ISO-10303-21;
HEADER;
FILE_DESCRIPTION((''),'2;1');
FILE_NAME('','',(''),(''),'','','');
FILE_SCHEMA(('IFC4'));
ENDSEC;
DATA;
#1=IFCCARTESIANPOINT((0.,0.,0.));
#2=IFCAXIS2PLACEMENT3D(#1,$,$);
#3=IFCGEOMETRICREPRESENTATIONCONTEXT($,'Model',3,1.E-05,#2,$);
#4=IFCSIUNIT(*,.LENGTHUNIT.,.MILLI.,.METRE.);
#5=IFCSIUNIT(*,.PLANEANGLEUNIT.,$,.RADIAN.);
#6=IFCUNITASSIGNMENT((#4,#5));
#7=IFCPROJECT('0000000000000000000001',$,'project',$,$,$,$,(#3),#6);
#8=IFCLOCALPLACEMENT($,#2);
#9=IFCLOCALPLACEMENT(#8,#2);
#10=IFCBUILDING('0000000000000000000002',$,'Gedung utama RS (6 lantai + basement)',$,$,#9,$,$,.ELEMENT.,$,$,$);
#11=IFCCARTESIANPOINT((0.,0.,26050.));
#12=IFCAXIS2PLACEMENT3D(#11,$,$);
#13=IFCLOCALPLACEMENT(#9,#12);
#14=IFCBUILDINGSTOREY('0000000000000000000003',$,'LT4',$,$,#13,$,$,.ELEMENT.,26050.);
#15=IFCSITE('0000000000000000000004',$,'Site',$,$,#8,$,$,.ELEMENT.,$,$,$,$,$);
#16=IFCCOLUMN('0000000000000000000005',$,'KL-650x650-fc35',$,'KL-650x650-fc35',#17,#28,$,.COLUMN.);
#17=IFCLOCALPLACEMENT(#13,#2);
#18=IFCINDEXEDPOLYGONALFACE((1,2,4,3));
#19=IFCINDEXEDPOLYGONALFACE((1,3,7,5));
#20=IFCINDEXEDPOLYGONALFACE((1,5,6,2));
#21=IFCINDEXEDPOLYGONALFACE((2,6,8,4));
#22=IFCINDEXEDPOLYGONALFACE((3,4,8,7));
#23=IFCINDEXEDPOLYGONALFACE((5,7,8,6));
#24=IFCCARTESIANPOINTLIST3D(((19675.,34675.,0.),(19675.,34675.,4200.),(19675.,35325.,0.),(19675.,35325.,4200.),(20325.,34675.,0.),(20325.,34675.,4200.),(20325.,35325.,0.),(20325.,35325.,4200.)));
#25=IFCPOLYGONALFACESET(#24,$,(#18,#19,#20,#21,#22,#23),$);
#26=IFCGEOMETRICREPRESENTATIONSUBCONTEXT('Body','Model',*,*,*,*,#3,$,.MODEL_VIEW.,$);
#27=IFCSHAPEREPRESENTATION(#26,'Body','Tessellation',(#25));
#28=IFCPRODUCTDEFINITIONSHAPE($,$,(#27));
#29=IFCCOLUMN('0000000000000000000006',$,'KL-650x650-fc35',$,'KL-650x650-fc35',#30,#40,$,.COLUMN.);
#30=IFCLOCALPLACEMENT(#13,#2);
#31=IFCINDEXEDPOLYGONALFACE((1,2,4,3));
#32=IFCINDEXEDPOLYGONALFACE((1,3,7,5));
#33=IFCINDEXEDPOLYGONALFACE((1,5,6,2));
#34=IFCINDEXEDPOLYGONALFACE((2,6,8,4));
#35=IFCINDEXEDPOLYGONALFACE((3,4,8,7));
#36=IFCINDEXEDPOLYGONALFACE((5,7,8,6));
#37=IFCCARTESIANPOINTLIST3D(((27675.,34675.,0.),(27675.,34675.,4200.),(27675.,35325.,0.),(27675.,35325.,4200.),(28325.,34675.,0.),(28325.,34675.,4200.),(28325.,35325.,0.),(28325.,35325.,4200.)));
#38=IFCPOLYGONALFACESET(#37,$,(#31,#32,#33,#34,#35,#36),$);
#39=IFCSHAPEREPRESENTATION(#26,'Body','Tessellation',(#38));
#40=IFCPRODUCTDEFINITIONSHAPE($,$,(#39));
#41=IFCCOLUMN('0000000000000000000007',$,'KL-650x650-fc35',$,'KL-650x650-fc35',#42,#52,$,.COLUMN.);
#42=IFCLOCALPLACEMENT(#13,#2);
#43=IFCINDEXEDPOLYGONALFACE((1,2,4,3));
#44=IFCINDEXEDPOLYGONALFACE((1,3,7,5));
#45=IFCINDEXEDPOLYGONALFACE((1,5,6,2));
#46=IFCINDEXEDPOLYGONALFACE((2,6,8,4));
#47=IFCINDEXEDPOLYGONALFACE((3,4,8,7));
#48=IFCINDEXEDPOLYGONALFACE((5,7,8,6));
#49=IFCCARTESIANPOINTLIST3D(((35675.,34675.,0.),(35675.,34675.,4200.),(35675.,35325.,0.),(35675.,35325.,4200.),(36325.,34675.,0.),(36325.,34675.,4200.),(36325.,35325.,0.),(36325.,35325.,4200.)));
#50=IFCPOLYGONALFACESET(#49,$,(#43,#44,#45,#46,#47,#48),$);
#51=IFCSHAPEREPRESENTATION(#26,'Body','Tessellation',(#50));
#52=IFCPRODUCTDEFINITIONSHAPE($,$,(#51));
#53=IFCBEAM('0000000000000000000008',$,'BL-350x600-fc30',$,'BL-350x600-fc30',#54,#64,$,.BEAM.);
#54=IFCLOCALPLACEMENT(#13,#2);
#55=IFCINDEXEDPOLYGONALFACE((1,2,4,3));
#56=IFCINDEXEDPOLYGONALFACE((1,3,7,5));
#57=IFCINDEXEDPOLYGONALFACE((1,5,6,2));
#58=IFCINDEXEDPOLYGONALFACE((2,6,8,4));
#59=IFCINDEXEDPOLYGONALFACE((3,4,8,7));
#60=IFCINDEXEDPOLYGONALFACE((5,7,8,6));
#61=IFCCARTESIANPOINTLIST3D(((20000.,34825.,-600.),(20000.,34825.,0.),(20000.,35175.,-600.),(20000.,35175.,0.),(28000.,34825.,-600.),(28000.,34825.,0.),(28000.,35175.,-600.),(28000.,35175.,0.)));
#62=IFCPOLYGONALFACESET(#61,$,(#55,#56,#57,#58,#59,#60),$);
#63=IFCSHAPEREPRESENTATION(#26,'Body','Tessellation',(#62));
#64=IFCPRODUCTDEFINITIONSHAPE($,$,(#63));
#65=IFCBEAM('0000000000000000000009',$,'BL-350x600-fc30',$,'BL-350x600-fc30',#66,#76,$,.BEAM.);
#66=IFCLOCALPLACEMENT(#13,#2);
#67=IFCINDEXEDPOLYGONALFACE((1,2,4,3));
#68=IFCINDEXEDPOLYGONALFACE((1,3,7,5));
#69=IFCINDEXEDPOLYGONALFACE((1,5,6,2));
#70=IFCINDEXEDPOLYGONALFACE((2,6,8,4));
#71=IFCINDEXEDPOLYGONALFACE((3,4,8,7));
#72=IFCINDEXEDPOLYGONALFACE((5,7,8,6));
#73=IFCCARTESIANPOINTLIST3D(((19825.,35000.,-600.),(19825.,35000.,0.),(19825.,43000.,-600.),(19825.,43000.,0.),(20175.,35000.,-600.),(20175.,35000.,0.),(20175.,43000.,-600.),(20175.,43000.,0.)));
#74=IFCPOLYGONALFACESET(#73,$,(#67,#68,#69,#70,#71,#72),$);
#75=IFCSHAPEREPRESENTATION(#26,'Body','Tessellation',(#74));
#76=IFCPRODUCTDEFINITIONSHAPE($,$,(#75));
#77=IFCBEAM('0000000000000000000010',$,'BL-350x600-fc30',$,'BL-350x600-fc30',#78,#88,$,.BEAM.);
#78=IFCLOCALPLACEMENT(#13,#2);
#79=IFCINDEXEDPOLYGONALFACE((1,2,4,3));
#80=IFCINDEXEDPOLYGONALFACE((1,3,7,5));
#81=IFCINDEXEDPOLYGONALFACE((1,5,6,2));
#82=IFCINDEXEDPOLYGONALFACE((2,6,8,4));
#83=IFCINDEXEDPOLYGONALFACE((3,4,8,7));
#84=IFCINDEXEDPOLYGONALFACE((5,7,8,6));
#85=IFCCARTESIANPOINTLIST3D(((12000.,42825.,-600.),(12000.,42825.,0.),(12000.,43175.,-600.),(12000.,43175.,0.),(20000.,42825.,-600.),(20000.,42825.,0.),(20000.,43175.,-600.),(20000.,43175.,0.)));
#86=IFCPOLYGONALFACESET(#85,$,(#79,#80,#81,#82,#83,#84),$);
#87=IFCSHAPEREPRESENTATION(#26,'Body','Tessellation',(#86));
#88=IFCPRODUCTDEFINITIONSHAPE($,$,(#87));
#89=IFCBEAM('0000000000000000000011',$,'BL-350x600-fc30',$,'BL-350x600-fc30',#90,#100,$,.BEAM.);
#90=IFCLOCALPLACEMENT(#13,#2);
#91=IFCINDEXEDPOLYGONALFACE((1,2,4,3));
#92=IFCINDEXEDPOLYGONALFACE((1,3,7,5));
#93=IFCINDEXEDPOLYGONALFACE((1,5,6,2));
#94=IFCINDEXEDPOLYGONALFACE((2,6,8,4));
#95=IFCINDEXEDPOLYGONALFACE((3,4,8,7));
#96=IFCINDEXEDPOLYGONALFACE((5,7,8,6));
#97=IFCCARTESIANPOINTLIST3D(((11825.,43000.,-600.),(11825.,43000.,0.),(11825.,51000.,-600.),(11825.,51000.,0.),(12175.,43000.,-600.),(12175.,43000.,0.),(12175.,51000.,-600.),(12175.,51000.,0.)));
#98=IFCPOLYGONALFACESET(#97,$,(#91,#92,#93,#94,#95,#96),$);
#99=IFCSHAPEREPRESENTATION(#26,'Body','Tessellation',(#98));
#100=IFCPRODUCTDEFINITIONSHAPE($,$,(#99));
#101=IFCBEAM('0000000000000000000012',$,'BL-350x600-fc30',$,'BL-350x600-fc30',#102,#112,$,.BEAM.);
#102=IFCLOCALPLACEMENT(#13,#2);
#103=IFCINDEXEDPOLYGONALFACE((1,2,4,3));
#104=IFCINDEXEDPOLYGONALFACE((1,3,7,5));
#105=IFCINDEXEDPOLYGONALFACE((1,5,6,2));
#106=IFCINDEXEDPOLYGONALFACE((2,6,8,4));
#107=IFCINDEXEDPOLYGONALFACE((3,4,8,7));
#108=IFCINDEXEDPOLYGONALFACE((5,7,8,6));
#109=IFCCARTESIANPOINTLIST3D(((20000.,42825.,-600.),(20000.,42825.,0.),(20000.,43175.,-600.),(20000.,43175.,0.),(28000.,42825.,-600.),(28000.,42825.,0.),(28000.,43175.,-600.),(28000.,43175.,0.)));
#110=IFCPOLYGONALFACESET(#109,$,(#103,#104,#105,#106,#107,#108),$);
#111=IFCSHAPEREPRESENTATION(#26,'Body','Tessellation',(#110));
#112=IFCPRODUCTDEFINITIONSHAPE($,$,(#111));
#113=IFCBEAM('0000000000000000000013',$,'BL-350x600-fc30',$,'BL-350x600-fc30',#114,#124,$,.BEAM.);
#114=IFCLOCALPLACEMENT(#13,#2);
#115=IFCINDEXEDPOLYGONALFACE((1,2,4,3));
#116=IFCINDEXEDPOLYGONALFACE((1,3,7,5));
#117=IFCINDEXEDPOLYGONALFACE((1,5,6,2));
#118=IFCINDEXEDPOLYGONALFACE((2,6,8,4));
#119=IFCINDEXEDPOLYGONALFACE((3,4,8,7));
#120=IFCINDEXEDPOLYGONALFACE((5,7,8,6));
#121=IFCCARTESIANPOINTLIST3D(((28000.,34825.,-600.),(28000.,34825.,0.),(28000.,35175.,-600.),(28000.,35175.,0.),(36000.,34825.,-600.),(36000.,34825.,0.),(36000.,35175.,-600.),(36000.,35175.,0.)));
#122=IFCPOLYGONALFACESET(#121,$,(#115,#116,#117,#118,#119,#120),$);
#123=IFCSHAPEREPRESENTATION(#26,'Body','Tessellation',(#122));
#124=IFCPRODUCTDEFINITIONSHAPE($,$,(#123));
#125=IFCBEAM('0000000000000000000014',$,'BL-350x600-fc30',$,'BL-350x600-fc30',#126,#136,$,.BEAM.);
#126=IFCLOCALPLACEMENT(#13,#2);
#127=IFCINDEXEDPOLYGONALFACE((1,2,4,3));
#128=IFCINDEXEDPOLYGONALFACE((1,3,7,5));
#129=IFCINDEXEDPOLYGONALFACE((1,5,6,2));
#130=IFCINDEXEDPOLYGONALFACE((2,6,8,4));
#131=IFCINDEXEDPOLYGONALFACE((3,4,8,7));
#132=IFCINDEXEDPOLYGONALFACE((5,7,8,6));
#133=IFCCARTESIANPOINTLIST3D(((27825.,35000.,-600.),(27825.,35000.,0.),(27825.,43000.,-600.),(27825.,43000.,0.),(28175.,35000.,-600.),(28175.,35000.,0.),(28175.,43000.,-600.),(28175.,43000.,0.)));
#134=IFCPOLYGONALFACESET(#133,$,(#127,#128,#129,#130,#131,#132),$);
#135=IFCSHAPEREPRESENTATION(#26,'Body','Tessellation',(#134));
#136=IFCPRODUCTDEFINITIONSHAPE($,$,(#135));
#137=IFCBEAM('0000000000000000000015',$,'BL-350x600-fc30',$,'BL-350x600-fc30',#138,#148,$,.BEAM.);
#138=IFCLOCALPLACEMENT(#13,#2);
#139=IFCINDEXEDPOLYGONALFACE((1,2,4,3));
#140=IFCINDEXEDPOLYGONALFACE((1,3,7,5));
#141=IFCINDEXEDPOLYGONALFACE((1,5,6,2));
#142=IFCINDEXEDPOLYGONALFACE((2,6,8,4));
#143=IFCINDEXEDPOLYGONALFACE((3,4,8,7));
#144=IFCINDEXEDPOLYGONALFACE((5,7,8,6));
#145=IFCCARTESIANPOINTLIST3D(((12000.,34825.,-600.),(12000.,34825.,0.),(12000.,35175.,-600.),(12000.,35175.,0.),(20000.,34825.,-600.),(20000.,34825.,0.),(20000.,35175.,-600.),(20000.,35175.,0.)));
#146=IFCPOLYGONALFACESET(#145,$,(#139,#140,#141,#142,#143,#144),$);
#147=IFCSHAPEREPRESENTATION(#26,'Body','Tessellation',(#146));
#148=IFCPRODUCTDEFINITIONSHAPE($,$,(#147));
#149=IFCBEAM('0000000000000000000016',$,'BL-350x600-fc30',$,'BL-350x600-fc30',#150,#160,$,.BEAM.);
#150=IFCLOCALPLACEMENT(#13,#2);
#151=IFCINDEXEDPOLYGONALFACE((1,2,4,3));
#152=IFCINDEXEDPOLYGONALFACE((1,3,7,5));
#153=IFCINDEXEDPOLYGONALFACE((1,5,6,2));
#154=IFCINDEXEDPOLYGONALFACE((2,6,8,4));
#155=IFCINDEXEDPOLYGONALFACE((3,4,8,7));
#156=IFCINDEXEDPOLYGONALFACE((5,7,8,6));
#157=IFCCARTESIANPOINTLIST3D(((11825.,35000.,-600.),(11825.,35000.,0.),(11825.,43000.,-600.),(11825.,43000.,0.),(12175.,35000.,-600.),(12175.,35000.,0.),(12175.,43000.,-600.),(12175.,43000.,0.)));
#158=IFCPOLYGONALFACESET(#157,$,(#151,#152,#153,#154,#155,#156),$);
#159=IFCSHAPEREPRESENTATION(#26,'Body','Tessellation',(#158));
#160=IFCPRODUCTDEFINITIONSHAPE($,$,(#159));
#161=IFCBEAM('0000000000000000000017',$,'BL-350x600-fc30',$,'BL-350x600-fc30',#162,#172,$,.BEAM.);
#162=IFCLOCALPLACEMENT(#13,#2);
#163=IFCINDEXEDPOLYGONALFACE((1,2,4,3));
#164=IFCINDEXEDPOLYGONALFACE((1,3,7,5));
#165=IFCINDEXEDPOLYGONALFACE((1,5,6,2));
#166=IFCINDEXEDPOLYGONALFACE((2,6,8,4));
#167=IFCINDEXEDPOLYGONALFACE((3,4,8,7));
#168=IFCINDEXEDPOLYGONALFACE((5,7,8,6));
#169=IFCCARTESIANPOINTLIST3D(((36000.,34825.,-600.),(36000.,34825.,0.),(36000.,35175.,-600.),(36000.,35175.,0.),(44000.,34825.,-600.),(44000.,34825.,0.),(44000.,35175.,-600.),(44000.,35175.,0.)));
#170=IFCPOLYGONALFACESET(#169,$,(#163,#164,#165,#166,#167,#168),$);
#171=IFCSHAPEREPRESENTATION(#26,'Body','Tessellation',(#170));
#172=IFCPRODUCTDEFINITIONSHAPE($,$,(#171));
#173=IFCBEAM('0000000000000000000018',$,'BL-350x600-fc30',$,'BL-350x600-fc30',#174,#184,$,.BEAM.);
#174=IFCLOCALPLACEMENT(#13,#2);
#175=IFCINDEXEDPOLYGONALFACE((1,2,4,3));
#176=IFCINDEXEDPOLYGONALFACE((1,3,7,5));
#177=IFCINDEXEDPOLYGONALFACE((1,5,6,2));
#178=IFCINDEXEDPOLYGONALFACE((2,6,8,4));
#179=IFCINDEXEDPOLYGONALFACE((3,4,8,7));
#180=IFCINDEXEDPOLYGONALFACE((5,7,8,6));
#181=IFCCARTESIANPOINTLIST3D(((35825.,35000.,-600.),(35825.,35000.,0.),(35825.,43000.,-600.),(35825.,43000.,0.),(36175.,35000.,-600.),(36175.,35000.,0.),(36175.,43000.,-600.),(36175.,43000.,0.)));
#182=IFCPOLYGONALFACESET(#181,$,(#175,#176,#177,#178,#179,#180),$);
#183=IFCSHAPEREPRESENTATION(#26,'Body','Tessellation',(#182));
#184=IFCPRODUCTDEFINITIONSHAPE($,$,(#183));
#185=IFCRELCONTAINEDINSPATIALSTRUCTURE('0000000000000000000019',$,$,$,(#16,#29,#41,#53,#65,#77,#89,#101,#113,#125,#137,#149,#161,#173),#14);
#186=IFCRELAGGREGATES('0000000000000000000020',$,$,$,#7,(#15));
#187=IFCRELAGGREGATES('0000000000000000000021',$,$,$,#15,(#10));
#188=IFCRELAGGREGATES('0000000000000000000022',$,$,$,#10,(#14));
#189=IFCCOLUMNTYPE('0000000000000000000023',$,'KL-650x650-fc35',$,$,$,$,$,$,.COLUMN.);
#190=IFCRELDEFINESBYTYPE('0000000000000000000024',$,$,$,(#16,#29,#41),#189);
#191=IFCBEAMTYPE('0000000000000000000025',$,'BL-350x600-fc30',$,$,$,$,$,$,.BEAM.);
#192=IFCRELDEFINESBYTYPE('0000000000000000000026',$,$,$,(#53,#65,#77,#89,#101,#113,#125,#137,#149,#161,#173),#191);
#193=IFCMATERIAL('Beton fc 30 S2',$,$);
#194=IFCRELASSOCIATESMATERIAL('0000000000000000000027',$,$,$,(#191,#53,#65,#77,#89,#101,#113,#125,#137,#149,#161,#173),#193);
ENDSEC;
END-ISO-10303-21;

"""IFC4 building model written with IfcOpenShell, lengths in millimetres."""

from ifc_helpers import new_model, si_unit, frame, origin, origin_2d, place, context, subcontext, project, spatial, rectangle, extrude, material, material_profile, profile_set, profile_usage, type_object, element, save


model = new_model("IFC4")

# Units and contexts
model_context = context("Model", 3, precision=1e-05, world=origin())
body_context = subcontext(model_context, "Body", "Model", "MODEL_VIEW")
ifc_project = project(units=[si_unit("LENGTHUNIT", "METRE", prefix="MILLI"), si_unit("PLANEANGLEUNIT", "RADIAN")], contexts=[model_context])

# Site, building, storey
site_placement = place(None, origin())
site = spatial("IfcSite", under=ifc_project, at=site_placement, Name="Site", CompositionType="ELEMENT")
building_placement = place(site_placement, origin())
building = spatial("IfcBuilding", under=site, at=building_placement, Name="Gedung utama RS (6 lantai + basement)", CompositionType="ELEMENT")
storey_placement = place(building_placement, frame((0.0, 0.0, 26050.0)))
storey = spatial("IfcBuildingStorey", under=building, at=storey_placement, Name="LT4", CompositionType="ELEMENT", Elevation=26050.0)

# Columns
ifc_material_profile_1 = material_profile(None, rectangle(XDim=650.0, YDim=650.0, at=origin_2d()), Name="KL-650x650-fc35")
ifc_profile_set_1 = profile_set([ifc_material_profile_1], Name="KL-650x650-fc35")
ifc_profile_usage_1 = profile_usage(ifc_profile_set_1, cardinal=5)
column_type = type_object("IfcColumnType", Name="KL-650x650-fc35", PredefinedType="COLUMN", material=ifc_profile_set_1)
for number, where, z_axis, x_axis, name in (
    (1, (20000.0, 35000.0, 0.0), (0.0, 0.0, 1.0), (1.0, 0.0, 0.0), "KL-650x650-fc35"),
    (2, (28000.0, 35000.0, 0.0), (0.0, 0.0, 1.0), (1.0, 0.0, 0.0), "KL-650x650-fc35"),
    (3, (36000.0, 35000.0, 0.0), (0.0, 0.0, 1.0), (1.0, 0.0, 0.0), "KL-650x650-fc35"),
):
    element("IfcColumn", number, at=place(storey_placement, frame(where, z_axis=z_axis, x_axis=x_axis)), inside=storey, type_object=column_type, material=ifc_profile_usage_1, Name=name, ObjectType="KL-650x650-fc35", PredefinedType="COLUMN", context=body_context, shape_type="SweptSolid", body=[
        extrude(rectangle(XDim=650.0, YDim=650.0, at=origin_2d()), origin(), (0.0, 0.0, 1.0), 4200.0),
    ])

# Beams
ifc_material_1 = material(Name="Beton fc 30 S2")
ifc_material_profile_2 = material_profile(ifc_material_1, rectangle(XDim=350.0, YDim=600.0, at=origin_2d()), Name="BL-350x600-fc30")
ifc_profile_set_2 = profile_set([ifc_material_profile_2], Name="BL-350x600-fc30")
ifc_profile_usage_2 = profile_usage(ifc_profile_set_2, cardinal=8)
beam_type = type_object("IfcBeamType", Name="BL-350x600-fc30", PredefinedType="BEAM", material=ifc_profile_set_2)
beam_1_placement = place(storey_placement, frame((20000.0, 35000.0, -300.0)))
element("IfcBeam", 4, at=beam_1_placement, inside=storey, type_object=beam_type, material=ifc_profile_usage_2, Name="BL-350x600-fc30", ObjectType="BL-350x600-fc30", PredefinedType="BEAM", context=body_context, shape_type="SweptSolid", body=[
    extrude(rectangle(XDim=350.0, YDim=600.0, at=origin_2d()), frame((0.0, 0.0, 0.0), z_axis=(1.0, 0.0, 0.0), x_axis=(0.0, 1.0, 0.0)), (0.0, 0.0, 1.0), 8000.0),
])
beam_2_placement = place(storey_placement, frame((20000.0, 35000.0, -300.0)))
element("IfcBeam", 5, at=beam_2_placement, inside=storey, type_object=beam_type, material=ifc_profile_usage_2, Name="BL-350x600-fc30", ObjectType="BL-350x600-fc30", PredefinedType="BEAM", context=body_context, shape_type="SweptSolid", body=[
    extrude(rectangle(XDim=350.0, YDim=600.0, at=origin_2d()), frame((0.0, 0.0, 0.0), z_axis=(0.0, 1.0, 0.0), x_axis=(-1.0, 0.0, 0.0)), (0.0, 0.0, 1.0), 8000.0),
])
beam_3_placement = place(storey_placement, frame((12000.0, 43000.0, -300.0)))
element("IfcBeam", 6, at=beam_3_placement, inside=storey, type_object=beam_type, material=ifc_profile_usage_2, Name="BL-350x600-fc30", ObjectType="BL-350x600-fc30", PredefinedType="BEAM", context=body_context, shape_type="SweptSolid", body=[
    extrude(rectangle(XDim=350.0, YDim=600.0, at=origin_2d()), frame((0.0, 0.0, 0.0), z_axis=(1.0, 0.0, 0.0), x_axis=(0.0, 1.0, 0.0)), (0.0, 0.0, 1.0), 8000.0),
])
beam_4_placement = place(storey_placement, frame((12000.0, 43000.0, -300.0)))
element("IfcBeam", 7, at=beam_4_placement, inside=storey, type_object=beam_type, material=ifc_profile_usage_2, Name="BL-350x600-fc30", ObjectType="BL-350x600-fc30", PredefinedType="BEAM", context=body_context, shape_type="SweptSolid", body=[
    extrude(rectangle(XDim=350.0, YDim=600.0, at=origin_2d()), frame((0.0, 0.0, 0.0), z_axis=(0.0, 1.0, 0.0), x_axis=(-1.0, 0.0, 0.0)), (0.0, 0.0, 1.0), 8000.0),
])
for number, where, name in (
    (8, (20000.0, 43000.0, -300.0), "BL-350x600-fc30"),
    (9, (28000.0, 35000.0, -300.0), "BL-350x600-fc30"),
):
    element("IfcBeam", number, at=place(storey_placement, frame(where)), inside=storey, type_object=beam_type, material=ifc_profile_usage_2, Name=name, ObjectType="BL-350x600-fc30", PredefinedType="BEAM", context=body_context, shape_type="SweptSolid", body=[
        extrude(rectangle(XDim=350.0, YDim=600.0, at=origin_2d()), frame((0.0, 0.0, 0.0), z_axis=(1.0, 0.0, 0.0), x_axis=(0.0, 1.0, 0.0)), (0.0, 0.0, 1.0), 8000.0),
    ])
beam_5_placement = place(storey_placement, frame((28000.0, 35000.0, -300.0)))
element("IfcBeam", 10, at=beam_5_placement, inside=storey, type_object=beam_type, material=ifc_profile_usage_2, Name="BL-350x600-fc30", ObjectType="BL-350x600-fc30", PredefinedType="BEAM", context=body_context, shape_type="SweptSolid", body=[
    extrude(rectangle(XDim=350.0, YDim=600.0, at=origin_2d()), frame((0.0, 0.0, 0.0), z_axis=(0.0, 1.0, 0.0), x_axis=(-1.0, 0.0, 0.0)), (0.0, 0.0, 1.0), 8000.0),
])
beam_6_placement = place(storey_placement, frame((12000.0, 35000.0, -300.0)))
element("IfcBeam", 11, at=beam_6_placement, inside=storey, type_object=beam_type, material=ifc_profile_usage_2, Name="BL-350x600-fc30", ObjectType="BL-350x600-fc30", PredefinedType="BEAM", context=body_context, shape_type="SweptSolid", body=[
    extrude(rectangle(XDim=350.0, YDim=600.0, at=origin_2d()), frame((0.0, 0.0, 0.0), z_axis=(1.0, 0.0, 0.0), x_axis=(0.0, 1.0, 0.0)), (0.0, 0.0, 1.0), 8000.0),
])
beam_7_placement = place(storey_placement, frame((12000.0, 35000.0, -300.0)))
element("IfcBeam", 12, at=beam_7_placement, inside=storey, type_object=beam_type, material=ifc_profile_usage_2, Name="BL-350x600-fc30", ObjectType="BL-350x600-fc30", PredefinedType="BEAM", context=body_context, shape_type="SweptSolid", body=[
    extrude(rectangle(XDim=350.0, YDim=600.0, at=origin_2d()), frame((0.0, 0.0, 0.0), z_axis=(0.0, 1.0, 0.0), x_axis=(-1.0, 0.0, 0.0)), (0.0, 0.0, 1.0), 8000.0),
])
beam_8_placement = place(storey_placement, frame((36000.0, 35000.0, -300.0)))
element("IfcBeam", 13, at=beam_8_placement, inside=storey, type_object=beam_type, material=ifc_profile_usage_2, Name="BL-350x600-fc30", ObjectType="BL-350x600-fc30", PredefinedType="BEAM", context=body_context, shape_type="SweptSolid", body=[
    extrude(rectangle(XDim=350.0, YDim=600.0, at=origin_2d()), frame((0.0, 0.0, 0.0), z_axis=(1.0, 0.0, 0.0), x_axis=(0.0, 1.0, 0.0)), (0.0, 0.0, 1.0), 8000.0),
])
beam_9_placement = place(storey_placement, frame((36000.0, 35000.0, -300.0)))
element("IfcBeam", 14, at=beam_9_placement, inside=storey, type_object=beam_type, material=ifc_profile_usage_2, Name="BL-350x600-fc30", ObjectType="BL-350x600-fc30", PredefinedType="BEAM", context=body_context, shape_type="SweptSolid", body=[
    extrude(rectangle(XDim=350.0, YDim=600.0, at=origin_2d()), frame((0.0, 0.0, 0.0), z_axis=(0.0, 1.0, 0.0), x_axis=(-1.0, 0.0, 0.0)), (0.0, 0.0, 1.0), 8000.0),
])

save(model, "model.ifc")
